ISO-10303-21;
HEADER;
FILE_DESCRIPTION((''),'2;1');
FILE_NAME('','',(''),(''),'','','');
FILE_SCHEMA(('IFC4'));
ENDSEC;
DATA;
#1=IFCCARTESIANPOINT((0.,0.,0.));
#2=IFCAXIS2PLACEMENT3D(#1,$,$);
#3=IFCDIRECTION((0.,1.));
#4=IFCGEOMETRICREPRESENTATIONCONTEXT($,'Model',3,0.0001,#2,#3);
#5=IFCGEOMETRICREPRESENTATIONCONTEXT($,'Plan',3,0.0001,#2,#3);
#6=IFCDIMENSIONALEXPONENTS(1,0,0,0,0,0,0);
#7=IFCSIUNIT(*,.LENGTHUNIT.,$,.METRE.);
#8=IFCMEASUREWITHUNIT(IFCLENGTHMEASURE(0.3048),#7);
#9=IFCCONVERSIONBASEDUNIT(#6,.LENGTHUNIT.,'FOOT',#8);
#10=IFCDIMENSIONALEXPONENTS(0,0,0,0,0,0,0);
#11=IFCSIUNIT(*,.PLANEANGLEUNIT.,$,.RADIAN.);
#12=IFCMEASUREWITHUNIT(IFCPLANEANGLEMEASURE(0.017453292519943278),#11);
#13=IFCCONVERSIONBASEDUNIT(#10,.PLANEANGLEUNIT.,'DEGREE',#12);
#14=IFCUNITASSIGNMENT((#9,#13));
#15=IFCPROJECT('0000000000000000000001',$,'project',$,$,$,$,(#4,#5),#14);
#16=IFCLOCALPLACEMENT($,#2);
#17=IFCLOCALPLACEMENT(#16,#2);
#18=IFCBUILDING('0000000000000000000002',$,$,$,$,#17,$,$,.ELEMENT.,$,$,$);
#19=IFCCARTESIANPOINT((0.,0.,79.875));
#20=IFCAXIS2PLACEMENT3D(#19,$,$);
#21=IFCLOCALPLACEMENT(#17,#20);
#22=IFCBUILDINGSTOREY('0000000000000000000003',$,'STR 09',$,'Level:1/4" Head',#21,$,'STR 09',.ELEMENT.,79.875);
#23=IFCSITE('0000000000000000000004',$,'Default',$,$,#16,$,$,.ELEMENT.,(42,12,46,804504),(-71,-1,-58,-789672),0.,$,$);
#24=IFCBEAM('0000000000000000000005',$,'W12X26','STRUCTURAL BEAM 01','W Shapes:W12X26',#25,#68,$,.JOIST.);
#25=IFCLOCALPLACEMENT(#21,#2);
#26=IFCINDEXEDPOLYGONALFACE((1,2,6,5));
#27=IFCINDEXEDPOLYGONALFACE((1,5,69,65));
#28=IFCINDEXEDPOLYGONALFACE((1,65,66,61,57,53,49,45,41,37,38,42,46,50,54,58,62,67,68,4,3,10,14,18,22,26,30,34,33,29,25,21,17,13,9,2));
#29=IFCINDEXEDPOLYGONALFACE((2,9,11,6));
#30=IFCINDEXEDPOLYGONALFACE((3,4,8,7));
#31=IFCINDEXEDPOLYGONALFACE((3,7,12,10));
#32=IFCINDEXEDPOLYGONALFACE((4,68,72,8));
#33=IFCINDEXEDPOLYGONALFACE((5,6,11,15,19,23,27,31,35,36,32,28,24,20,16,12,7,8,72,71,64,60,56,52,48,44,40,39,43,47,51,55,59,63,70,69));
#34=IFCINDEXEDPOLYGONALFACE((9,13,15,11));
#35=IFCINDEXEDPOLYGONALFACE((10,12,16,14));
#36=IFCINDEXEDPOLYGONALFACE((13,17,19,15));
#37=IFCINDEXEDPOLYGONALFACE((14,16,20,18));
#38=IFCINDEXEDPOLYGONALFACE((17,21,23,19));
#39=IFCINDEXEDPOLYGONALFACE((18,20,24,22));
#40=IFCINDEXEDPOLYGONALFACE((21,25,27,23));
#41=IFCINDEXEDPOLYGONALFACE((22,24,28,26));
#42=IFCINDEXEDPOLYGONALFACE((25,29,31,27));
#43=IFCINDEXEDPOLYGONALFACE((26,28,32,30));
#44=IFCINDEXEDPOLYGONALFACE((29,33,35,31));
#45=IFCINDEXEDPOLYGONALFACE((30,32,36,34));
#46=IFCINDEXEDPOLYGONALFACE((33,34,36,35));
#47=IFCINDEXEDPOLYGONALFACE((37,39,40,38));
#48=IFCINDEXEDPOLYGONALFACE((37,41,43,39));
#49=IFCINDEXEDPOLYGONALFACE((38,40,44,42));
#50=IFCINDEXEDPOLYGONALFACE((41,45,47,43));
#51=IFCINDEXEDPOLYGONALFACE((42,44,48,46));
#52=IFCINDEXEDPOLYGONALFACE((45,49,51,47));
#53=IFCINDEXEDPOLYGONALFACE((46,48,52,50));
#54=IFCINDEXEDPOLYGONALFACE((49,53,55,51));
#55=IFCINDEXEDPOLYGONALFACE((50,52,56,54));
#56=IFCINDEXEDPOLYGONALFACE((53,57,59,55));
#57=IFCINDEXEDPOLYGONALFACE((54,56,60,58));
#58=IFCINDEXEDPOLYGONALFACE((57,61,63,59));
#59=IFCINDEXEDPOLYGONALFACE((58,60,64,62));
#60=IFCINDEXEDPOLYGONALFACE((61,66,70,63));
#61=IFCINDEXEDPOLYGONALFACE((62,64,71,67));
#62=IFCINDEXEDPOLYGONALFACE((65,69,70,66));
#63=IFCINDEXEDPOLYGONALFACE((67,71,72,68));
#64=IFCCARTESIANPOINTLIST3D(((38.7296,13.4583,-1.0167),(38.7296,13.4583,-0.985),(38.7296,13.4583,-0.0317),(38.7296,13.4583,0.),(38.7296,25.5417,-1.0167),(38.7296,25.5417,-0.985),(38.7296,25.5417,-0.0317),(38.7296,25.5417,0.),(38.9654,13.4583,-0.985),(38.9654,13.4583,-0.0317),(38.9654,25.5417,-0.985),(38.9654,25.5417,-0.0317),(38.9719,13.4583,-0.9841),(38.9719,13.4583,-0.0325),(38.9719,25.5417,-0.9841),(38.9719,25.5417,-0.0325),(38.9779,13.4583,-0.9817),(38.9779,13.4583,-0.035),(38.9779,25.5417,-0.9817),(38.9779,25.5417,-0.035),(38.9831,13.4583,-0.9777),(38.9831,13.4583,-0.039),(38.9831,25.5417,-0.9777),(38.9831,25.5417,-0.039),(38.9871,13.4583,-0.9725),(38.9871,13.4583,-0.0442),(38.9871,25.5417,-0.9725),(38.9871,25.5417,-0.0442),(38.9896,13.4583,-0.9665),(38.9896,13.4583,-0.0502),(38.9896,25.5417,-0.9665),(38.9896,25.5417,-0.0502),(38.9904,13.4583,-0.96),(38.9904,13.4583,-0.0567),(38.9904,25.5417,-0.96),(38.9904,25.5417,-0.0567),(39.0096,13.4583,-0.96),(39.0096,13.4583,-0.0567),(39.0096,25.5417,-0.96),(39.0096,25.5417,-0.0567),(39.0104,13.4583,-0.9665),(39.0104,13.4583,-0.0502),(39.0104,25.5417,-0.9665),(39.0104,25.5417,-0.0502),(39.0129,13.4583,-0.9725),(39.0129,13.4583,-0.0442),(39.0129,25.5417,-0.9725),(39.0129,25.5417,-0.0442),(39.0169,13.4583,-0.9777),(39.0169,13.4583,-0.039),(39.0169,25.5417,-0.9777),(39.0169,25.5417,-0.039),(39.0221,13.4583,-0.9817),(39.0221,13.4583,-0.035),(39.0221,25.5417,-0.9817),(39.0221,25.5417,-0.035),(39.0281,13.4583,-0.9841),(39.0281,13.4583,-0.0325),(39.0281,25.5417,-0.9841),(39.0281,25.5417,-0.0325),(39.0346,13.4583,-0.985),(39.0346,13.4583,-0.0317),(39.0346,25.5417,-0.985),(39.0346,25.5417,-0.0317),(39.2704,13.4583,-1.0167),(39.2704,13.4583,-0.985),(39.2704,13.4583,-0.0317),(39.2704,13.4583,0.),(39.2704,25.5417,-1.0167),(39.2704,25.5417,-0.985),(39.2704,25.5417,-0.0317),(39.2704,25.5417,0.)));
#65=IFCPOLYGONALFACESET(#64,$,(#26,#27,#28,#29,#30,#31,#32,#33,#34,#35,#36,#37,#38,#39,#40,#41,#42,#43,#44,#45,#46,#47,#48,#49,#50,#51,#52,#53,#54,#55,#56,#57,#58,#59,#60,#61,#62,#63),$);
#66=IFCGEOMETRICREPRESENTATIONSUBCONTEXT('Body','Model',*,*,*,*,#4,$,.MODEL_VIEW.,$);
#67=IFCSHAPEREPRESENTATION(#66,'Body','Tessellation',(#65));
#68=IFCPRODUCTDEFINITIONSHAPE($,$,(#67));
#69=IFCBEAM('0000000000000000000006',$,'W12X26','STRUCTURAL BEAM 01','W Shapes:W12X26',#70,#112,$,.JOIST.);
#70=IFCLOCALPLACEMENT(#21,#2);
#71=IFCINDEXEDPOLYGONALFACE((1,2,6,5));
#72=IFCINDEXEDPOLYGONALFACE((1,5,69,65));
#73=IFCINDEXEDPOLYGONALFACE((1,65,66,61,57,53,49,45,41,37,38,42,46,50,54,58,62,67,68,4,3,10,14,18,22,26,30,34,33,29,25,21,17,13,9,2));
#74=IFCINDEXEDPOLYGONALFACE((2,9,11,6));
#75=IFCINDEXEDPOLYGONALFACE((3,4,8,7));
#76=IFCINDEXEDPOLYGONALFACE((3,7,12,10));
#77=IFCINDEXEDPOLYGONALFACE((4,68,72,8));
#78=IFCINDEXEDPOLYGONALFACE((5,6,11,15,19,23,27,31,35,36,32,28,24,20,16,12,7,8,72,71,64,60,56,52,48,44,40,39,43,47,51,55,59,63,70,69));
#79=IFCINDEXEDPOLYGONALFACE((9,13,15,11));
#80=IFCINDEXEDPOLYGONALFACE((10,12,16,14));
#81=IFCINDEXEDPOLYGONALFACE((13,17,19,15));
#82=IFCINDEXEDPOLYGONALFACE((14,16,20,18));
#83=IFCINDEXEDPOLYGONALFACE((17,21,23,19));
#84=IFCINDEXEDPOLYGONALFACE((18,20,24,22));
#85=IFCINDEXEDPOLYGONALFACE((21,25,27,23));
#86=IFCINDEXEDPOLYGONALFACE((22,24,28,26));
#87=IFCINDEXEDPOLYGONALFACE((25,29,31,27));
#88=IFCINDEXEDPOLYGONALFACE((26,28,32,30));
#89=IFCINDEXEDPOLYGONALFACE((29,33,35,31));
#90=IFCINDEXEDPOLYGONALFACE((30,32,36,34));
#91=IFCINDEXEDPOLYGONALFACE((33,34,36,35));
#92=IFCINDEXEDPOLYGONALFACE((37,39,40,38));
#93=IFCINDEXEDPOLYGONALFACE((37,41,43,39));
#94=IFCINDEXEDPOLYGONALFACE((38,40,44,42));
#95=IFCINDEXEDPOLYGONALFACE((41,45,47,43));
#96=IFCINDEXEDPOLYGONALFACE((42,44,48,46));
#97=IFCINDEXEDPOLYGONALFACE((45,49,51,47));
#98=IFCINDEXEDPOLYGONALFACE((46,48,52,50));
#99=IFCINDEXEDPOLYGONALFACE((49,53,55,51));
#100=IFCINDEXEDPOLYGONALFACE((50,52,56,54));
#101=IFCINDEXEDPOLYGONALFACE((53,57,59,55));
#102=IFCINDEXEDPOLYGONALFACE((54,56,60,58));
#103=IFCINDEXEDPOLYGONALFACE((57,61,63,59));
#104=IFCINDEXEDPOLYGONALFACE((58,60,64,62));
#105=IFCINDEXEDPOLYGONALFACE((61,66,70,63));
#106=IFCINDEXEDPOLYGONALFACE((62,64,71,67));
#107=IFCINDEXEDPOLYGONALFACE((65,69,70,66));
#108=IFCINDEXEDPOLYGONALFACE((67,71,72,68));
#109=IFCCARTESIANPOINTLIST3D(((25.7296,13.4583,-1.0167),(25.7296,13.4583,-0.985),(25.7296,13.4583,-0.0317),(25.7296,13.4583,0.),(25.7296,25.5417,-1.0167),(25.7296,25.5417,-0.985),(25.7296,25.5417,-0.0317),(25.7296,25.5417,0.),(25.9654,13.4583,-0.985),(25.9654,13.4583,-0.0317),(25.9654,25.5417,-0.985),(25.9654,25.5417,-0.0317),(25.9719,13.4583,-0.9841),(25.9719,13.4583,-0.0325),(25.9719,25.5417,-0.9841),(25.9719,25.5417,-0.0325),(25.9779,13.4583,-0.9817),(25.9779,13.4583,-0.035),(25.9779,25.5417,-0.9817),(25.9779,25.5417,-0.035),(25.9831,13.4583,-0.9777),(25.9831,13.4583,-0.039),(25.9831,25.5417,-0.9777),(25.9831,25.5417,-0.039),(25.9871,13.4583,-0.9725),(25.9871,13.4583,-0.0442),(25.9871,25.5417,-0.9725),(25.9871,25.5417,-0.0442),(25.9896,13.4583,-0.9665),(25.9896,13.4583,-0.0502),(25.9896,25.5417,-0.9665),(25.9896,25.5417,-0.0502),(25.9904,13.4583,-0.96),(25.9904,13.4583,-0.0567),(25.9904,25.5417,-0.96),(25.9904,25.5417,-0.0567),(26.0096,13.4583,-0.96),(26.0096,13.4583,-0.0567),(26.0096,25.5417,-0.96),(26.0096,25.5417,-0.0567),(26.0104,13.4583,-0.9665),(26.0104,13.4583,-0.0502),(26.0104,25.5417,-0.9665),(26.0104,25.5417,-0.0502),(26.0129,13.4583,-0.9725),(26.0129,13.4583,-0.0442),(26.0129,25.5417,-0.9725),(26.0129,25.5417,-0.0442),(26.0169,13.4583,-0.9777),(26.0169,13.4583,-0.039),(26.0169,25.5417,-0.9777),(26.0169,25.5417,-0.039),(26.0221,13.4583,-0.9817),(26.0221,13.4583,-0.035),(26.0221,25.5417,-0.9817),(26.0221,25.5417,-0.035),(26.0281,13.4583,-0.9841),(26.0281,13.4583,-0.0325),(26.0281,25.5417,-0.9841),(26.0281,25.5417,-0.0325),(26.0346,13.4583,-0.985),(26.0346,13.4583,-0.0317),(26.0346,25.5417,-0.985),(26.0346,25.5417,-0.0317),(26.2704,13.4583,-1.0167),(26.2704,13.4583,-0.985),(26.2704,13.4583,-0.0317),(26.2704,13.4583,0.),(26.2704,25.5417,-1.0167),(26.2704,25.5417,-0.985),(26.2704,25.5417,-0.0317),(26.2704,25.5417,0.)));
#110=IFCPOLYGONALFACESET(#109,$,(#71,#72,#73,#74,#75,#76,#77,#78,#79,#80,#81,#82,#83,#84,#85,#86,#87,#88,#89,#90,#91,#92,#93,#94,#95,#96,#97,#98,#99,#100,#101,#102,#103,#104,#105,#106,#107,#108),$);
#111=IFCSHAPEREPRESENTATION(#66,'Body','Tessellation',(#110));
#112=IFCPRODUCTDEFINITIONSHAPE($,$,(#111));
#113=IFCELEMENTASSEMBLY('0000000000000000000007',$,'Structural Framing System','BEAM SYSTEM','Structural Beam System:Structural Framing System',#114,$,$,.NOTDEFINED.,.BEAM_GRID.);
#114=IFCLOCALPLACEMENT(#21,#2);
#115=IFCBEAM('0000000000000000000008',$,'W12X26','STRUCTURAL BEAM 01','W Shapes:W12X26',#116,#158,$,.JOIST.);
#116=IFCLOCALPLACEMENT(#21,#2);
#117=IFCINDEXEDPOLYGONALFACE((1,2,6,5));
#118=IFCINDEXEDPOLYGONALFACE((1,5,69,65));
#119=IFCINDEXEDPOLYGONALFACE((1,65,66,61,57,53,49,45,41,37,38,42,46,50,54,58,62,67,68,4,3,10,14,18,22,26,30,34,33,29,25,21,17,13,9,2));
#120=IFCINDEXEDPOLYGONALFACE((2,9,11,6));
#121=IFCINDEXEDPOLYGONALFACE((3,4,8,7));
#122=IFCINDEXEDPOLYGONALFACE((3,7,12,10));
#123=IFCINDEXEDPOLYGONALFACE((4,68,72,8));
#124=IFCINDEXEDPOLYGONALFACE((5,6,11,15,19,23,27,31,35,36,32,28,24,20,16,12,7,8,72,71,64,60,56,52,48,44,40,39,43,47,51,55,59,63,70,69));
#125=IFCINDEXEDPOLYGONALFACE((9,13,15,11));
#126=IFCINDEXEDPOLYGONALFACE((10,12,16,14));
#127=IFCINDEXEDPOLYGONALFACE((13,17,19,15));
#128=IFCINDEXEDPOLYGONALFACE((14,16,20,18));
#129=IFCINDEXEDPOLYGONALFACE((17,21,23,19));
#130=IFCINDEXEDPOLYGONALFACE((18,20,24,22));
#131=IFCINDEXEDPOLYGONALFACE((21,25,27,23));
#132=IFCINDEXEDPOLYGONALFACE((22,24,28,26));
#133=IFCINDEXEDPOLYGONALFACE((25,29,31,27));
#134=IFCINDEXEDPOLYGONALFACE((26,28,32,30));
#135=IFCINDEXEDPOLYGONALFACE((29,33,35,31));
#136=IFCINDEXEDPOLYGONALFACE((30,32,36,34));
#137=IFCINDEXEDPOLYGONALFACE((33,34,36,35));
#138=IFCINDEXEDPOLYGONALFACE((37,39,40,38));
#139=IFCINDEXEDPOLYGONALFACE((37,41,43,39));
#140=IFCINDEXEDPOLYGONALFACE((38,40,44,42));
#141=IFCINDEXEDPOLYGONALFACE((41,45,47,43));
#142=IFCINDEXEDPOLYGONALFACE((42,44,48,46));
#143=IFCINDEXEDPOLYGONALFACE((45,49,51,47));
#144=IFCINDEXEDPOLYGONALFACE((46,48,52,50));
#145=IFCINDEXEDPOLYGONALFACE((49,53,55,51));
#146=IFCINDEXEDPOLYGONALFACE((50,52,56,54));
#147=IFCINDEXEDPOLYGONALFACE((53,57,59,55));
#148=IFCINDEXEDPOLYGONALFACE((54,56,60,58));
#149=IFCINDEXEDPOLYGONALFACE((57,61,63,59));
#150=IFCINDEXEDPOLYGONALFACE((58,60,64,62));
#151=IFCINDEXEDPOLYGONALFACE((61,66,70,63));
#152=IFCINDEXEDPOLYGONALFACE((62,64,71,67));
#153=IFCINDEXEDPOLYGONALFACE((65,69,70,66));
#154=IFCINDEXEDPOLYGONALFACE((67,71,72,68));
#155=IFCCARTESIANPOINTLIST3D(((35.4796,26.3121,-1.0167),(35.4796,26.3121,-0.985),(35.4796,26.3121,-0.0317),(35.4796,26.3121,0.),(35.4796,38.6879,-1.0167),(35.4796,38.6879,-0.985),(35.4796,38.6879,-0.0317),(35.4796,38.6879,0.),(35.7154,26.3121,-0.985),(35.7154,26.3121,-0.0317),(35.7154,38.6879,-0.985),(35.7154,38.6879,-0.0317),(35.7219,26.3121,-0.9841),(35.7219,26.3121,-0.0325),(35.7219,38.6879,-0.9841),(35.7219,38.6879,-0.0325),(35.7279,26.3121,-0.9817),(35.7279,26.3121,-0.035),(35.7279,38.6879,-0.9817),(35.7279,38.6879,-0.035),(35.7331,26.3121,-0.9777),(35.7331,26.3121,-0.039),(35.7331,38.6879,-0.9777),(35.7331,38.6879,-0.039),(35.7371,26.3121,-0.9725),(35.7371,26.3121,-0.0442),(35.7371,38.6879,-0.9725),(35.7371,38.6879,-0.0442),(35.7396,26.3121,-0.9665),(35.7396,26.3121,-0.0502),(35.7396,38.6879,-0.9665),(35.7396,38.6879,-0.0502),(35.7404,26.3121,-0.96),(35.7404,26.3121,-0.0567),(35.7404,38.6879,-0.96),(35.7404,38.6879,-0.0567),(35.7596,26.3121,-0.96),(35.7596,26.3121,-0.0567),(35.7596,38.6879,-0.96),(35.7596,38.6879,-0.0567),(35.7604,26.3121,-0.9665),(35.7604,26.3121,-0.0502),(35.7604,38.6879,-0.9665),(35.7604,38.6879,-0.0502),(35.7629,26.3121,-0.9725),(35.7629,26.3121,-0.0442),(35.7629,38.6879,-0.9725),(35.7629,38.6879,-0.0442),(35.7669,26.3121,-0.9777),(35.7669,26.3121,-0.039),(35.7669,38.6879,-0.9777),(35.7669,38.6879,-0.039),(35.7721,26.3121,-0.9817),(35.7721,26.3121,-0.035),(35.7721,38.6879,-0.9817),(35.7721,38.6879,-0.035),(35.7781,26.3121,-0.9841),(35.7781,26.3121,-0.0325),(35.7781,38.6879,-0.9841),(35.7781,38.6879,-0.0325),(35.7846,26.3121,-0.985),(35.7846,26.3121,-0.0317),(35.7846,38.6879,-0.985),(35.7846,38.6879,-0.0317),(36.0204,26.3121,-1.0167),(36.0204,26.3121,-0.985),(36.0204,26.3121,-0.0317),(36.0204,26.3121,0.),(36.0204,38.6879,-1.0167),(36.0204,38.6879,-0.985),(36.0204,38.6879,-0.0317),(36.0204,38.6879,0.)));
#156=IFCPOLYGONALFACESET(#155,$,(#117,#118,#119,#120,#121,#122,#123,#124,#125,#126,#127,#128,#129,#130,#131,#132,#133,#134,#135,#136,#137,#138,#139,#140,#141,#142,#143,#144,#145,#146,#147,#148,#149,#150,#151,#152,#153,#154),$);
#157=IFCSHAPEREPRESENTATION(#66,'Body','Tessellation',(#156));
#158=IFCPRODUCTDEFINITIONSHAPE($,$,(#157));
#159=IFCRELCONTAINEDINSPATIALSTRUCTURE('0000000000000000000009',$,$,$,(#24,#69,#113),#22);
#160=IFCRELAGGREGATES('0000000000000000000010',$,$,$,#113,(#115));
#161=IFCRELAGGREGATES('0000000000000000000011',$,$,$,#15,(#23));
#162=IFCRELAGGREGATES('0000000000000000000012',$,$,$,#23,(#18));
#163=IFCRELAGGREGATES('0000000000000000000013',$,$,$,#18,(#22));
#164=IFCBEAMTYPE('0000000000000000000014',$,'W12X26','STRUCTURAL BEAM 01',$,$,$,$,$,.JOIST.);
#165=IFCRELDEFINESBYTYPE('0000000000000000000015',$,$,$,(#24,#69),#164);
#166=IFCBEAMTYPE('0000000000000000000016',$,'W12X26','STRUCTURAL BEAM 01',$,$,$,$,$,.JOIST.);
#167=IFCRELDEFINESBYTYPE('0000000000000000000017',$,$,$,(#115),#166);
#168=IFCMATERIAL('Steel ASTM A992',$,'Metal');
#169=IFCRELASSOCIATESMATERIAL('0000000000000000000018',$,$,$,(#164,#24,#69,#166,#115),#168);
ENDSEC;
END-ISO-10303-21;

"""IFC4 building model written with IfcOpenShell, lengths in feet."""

from ifc_helpers import new_model, entity, si_unit, converted_unit, direction, frame, origin, place, context, subcontext, project, spatial, line, arc, indexed_curve, outline, extrude, source, transform, mapped, material, type_object, type_shapes, element, aggregate, save


model = new_model("IFC4")

# Units and contexts
model_context = context("Model", 3, precision=0.0001, world=origin(), true_north=direction((0.0, 1.0)))
plan_context = context("Plan", 3, precision=0.0001, world=origin(), true_north=direction((0.0, 1.0)))
body_context = subcontext(model_context, "Body", "Model", "MODEL_VIEW")
ifc_project = project(units=[converted_unit("LENGTHUNIT", "FOOT", entity("IfcLengthMeasure", 0.3048), si_unit("LENGTHUNIT", "METRE"), dimensions=[1, 0, 0, 0, 0, 0, 0]), converted_unit("PLANEANGLEUNIT", "DEGREE", entity("IfcPlaneAngleMeasure", 0.017453292519943278), si_unit("PLANEANGLEUNIT", "RADIAN"), dimensions=[0, 0, 0, 0, 0, 0, 0])], contexts=[model_context, plan_context])

# Site, building, storey
site_placement = place(None, origin())
site = spatial("IfcSite", under=ifc_project, at=site_placement, Name="Default", CompositionType="ELEMENT", RefLatitude=(42, 12, 46, 804504), RefLongitude=(-71, -1, -58, -789672), RefElevation=0.0)
building_placement = place(site_placement, origin())
building = spatial("IfcBuilding", under=site, at=building_placement, CompositionType="ELEMENT")
storey_placement = place(building_placement, frame((0.0, 0.0, 79.875)))
storey = spatial("IfcBuildingStorey", under=building, at=storey_placement, Name="STR 09", ObjectType="Level:1/4\" Head", LongName="STR 09", CompositionType="ELEMENT", Elevation=79.875)

# Beams
ifc_material = material(Name="Steel ASTM A992", Category="Metal")
beam_type_1 = type_object("IfcBeamType", Name="W12X26", Description="STRUCTURAL BEAM 01", PredefinedType="JOIST", material=ifc_material)
shared_shape_1 = source(origin(), body_context, "Body", "SweptSolid", [
    extrude(outline(indexed_curve([(-0.2704, -0.4767), (-0.2704, -0.5083), (0.2704, -0.5083), (0.2704, -0.4767), (0.0346, -0.4767), (0.0169, -0.4693), (0.0096, -0.4517), (0.0096, 0.4517), (0.0169, 0.4693), (0.0346, 0.4767), (0.2704, 0.4767), (0.2704, 0.5083), (-0.2704, 0.5083), (-0.2704, 0.4767), (-0.0346, 0.4767), (-0.0169, 0.4693), (-0.0096, 0.4517), (-0.0096, -0.4517), (-0.0169, -0.4693), (-0.0346, -0.4767)], segments=[line(1, 2, 3, 4, 5), arc(5, 6, 7), line(7, 8), arc(8, 9, 10), line(10, 11, 12, 13, 14, 15), arc(15, 16, 17), line(17, 18), arc(18, 19, 20), line(20, 1)], self_intersect=False)), frame((-6.2267, 0.0, 0.0), z_axis=(-1.0, 0.0, 0.0), x_axis=(0.0, -1.0, 0.0)), (0.0, 0.0, -1.0), 12.0833),
])
type_shapes(beam_type_1, [shared_shape_1])
for number, where, z_axis, x_axis, name in (
    (1, (39.0, 19.685, -0.5083), (0.0, 0.0, 1.0), (0.0, 1.0, 0.0), "W12X26"),
    (2, (26.0, 19.685, -0.5083), (0.0, 0.0, 1.0), (0.0, 1.0, 0.0), "W12X26"),
):
    element("IfcBeam", number, at=place(storey_placement, frame(where, z_axis=z_axis, x_axis=x_axis)), inside=storey, type_object=beam_type_1, material=ifc_material, Name=name, Description="STRUCTURAL BEAM 01", ObjectType="W Shapes:W12X26", PredefinedType="JOIST", context=body_context, shape_type="MappedRepresentation", body=[
        mapped(shared_shape_1, transform((0.0, 0.0, 0.0), scale=1.0)),
    ])

# Element assembly, beam
assembly_placement = place(storey_placement, origin())
assembly = element("IfcElementAssembly", 3, at=assembly_placement, inside=storey, Name="Structural Framing System", Description="BEAM SYSTEM", ObjectType="Structural Beam System:Structural Framing System", AssemblyPlace="NOTDEFINED", PredefinedType="BEAM_GRID")
beam_type_2 = type_object("IfcBeamType", Name="W12X26", Description="STRUCTURAL BEAM 01", PredefinedType="JOIST", material=ifc_material)
shared_shape_2 = source(origin(), body_context, "Body", "SweptSolid", [
    extrude(outline(indexed_curve([(-0.2704, -0.4767), (-0.2704, -0.5083), (0.2704, -0.5083), (0.2704, -0.4767), (0.0346, -0.4767), (0.0169, -0.4693), (0.0096, -0.4517), (0.0096, 0.4517), (0.0169, 0.4693), (0.0346, 0.4767), (0.2704, 0.4767), (0.2704, 0.5083), (-0.2704, 0.5083), (-0.2704, 0.4767), (-0.0346, 0.4767), (-0.0169, 0.4693), (-0.0096, 0.4517), (-0.0096, -0.4517), (-0.0169, -0.4693), (-0.0346, -0.4767)], segments=[line(1, 2, 3, 4, 5), arc(5, 6, 7), line(7, 8), arc(8, 9, 10), line(10, 11, 12, 13, 14, 15), arc(15, 16, 17), line(17, 18), arc(18, 19, 20), line(20, 1)], self_intersect=False)), frame((-6.1879, 0.0, 0.0), z_axis=(-1.0, 0.0, 0.0), x_axis=(0.0, -1.0, 0.0)), (0.0, 0.0, -1.0), 12.3758),
])
type_shapes(beam_type_2, [shared_shape_2])
beam_1_placement = place(assembly_placement, frame((35.75, 32.5, -0.5083), z_axis=(0.0, 0.0, 1.0), x_axis=(0.0, 1.0, 0.0)))
beam_1 = element("IfcBeam", 4, at=beam_1_placement, type_object=beam_type_2, material=ifc_material, Name="W12X26", Description="STRUCTURAL BEAM 01", ObjectType="W Shapes:W12X26", PredefinedType="JOIST", context=body_context, shape_type="MappedRepresentation", body=[
    mapped(shared_shape_2, transform((0.0, 0.0, 0.0), scale=1.0)),
])
aggregate(assembly, [beam_1])

save(model, "model.ifc")
